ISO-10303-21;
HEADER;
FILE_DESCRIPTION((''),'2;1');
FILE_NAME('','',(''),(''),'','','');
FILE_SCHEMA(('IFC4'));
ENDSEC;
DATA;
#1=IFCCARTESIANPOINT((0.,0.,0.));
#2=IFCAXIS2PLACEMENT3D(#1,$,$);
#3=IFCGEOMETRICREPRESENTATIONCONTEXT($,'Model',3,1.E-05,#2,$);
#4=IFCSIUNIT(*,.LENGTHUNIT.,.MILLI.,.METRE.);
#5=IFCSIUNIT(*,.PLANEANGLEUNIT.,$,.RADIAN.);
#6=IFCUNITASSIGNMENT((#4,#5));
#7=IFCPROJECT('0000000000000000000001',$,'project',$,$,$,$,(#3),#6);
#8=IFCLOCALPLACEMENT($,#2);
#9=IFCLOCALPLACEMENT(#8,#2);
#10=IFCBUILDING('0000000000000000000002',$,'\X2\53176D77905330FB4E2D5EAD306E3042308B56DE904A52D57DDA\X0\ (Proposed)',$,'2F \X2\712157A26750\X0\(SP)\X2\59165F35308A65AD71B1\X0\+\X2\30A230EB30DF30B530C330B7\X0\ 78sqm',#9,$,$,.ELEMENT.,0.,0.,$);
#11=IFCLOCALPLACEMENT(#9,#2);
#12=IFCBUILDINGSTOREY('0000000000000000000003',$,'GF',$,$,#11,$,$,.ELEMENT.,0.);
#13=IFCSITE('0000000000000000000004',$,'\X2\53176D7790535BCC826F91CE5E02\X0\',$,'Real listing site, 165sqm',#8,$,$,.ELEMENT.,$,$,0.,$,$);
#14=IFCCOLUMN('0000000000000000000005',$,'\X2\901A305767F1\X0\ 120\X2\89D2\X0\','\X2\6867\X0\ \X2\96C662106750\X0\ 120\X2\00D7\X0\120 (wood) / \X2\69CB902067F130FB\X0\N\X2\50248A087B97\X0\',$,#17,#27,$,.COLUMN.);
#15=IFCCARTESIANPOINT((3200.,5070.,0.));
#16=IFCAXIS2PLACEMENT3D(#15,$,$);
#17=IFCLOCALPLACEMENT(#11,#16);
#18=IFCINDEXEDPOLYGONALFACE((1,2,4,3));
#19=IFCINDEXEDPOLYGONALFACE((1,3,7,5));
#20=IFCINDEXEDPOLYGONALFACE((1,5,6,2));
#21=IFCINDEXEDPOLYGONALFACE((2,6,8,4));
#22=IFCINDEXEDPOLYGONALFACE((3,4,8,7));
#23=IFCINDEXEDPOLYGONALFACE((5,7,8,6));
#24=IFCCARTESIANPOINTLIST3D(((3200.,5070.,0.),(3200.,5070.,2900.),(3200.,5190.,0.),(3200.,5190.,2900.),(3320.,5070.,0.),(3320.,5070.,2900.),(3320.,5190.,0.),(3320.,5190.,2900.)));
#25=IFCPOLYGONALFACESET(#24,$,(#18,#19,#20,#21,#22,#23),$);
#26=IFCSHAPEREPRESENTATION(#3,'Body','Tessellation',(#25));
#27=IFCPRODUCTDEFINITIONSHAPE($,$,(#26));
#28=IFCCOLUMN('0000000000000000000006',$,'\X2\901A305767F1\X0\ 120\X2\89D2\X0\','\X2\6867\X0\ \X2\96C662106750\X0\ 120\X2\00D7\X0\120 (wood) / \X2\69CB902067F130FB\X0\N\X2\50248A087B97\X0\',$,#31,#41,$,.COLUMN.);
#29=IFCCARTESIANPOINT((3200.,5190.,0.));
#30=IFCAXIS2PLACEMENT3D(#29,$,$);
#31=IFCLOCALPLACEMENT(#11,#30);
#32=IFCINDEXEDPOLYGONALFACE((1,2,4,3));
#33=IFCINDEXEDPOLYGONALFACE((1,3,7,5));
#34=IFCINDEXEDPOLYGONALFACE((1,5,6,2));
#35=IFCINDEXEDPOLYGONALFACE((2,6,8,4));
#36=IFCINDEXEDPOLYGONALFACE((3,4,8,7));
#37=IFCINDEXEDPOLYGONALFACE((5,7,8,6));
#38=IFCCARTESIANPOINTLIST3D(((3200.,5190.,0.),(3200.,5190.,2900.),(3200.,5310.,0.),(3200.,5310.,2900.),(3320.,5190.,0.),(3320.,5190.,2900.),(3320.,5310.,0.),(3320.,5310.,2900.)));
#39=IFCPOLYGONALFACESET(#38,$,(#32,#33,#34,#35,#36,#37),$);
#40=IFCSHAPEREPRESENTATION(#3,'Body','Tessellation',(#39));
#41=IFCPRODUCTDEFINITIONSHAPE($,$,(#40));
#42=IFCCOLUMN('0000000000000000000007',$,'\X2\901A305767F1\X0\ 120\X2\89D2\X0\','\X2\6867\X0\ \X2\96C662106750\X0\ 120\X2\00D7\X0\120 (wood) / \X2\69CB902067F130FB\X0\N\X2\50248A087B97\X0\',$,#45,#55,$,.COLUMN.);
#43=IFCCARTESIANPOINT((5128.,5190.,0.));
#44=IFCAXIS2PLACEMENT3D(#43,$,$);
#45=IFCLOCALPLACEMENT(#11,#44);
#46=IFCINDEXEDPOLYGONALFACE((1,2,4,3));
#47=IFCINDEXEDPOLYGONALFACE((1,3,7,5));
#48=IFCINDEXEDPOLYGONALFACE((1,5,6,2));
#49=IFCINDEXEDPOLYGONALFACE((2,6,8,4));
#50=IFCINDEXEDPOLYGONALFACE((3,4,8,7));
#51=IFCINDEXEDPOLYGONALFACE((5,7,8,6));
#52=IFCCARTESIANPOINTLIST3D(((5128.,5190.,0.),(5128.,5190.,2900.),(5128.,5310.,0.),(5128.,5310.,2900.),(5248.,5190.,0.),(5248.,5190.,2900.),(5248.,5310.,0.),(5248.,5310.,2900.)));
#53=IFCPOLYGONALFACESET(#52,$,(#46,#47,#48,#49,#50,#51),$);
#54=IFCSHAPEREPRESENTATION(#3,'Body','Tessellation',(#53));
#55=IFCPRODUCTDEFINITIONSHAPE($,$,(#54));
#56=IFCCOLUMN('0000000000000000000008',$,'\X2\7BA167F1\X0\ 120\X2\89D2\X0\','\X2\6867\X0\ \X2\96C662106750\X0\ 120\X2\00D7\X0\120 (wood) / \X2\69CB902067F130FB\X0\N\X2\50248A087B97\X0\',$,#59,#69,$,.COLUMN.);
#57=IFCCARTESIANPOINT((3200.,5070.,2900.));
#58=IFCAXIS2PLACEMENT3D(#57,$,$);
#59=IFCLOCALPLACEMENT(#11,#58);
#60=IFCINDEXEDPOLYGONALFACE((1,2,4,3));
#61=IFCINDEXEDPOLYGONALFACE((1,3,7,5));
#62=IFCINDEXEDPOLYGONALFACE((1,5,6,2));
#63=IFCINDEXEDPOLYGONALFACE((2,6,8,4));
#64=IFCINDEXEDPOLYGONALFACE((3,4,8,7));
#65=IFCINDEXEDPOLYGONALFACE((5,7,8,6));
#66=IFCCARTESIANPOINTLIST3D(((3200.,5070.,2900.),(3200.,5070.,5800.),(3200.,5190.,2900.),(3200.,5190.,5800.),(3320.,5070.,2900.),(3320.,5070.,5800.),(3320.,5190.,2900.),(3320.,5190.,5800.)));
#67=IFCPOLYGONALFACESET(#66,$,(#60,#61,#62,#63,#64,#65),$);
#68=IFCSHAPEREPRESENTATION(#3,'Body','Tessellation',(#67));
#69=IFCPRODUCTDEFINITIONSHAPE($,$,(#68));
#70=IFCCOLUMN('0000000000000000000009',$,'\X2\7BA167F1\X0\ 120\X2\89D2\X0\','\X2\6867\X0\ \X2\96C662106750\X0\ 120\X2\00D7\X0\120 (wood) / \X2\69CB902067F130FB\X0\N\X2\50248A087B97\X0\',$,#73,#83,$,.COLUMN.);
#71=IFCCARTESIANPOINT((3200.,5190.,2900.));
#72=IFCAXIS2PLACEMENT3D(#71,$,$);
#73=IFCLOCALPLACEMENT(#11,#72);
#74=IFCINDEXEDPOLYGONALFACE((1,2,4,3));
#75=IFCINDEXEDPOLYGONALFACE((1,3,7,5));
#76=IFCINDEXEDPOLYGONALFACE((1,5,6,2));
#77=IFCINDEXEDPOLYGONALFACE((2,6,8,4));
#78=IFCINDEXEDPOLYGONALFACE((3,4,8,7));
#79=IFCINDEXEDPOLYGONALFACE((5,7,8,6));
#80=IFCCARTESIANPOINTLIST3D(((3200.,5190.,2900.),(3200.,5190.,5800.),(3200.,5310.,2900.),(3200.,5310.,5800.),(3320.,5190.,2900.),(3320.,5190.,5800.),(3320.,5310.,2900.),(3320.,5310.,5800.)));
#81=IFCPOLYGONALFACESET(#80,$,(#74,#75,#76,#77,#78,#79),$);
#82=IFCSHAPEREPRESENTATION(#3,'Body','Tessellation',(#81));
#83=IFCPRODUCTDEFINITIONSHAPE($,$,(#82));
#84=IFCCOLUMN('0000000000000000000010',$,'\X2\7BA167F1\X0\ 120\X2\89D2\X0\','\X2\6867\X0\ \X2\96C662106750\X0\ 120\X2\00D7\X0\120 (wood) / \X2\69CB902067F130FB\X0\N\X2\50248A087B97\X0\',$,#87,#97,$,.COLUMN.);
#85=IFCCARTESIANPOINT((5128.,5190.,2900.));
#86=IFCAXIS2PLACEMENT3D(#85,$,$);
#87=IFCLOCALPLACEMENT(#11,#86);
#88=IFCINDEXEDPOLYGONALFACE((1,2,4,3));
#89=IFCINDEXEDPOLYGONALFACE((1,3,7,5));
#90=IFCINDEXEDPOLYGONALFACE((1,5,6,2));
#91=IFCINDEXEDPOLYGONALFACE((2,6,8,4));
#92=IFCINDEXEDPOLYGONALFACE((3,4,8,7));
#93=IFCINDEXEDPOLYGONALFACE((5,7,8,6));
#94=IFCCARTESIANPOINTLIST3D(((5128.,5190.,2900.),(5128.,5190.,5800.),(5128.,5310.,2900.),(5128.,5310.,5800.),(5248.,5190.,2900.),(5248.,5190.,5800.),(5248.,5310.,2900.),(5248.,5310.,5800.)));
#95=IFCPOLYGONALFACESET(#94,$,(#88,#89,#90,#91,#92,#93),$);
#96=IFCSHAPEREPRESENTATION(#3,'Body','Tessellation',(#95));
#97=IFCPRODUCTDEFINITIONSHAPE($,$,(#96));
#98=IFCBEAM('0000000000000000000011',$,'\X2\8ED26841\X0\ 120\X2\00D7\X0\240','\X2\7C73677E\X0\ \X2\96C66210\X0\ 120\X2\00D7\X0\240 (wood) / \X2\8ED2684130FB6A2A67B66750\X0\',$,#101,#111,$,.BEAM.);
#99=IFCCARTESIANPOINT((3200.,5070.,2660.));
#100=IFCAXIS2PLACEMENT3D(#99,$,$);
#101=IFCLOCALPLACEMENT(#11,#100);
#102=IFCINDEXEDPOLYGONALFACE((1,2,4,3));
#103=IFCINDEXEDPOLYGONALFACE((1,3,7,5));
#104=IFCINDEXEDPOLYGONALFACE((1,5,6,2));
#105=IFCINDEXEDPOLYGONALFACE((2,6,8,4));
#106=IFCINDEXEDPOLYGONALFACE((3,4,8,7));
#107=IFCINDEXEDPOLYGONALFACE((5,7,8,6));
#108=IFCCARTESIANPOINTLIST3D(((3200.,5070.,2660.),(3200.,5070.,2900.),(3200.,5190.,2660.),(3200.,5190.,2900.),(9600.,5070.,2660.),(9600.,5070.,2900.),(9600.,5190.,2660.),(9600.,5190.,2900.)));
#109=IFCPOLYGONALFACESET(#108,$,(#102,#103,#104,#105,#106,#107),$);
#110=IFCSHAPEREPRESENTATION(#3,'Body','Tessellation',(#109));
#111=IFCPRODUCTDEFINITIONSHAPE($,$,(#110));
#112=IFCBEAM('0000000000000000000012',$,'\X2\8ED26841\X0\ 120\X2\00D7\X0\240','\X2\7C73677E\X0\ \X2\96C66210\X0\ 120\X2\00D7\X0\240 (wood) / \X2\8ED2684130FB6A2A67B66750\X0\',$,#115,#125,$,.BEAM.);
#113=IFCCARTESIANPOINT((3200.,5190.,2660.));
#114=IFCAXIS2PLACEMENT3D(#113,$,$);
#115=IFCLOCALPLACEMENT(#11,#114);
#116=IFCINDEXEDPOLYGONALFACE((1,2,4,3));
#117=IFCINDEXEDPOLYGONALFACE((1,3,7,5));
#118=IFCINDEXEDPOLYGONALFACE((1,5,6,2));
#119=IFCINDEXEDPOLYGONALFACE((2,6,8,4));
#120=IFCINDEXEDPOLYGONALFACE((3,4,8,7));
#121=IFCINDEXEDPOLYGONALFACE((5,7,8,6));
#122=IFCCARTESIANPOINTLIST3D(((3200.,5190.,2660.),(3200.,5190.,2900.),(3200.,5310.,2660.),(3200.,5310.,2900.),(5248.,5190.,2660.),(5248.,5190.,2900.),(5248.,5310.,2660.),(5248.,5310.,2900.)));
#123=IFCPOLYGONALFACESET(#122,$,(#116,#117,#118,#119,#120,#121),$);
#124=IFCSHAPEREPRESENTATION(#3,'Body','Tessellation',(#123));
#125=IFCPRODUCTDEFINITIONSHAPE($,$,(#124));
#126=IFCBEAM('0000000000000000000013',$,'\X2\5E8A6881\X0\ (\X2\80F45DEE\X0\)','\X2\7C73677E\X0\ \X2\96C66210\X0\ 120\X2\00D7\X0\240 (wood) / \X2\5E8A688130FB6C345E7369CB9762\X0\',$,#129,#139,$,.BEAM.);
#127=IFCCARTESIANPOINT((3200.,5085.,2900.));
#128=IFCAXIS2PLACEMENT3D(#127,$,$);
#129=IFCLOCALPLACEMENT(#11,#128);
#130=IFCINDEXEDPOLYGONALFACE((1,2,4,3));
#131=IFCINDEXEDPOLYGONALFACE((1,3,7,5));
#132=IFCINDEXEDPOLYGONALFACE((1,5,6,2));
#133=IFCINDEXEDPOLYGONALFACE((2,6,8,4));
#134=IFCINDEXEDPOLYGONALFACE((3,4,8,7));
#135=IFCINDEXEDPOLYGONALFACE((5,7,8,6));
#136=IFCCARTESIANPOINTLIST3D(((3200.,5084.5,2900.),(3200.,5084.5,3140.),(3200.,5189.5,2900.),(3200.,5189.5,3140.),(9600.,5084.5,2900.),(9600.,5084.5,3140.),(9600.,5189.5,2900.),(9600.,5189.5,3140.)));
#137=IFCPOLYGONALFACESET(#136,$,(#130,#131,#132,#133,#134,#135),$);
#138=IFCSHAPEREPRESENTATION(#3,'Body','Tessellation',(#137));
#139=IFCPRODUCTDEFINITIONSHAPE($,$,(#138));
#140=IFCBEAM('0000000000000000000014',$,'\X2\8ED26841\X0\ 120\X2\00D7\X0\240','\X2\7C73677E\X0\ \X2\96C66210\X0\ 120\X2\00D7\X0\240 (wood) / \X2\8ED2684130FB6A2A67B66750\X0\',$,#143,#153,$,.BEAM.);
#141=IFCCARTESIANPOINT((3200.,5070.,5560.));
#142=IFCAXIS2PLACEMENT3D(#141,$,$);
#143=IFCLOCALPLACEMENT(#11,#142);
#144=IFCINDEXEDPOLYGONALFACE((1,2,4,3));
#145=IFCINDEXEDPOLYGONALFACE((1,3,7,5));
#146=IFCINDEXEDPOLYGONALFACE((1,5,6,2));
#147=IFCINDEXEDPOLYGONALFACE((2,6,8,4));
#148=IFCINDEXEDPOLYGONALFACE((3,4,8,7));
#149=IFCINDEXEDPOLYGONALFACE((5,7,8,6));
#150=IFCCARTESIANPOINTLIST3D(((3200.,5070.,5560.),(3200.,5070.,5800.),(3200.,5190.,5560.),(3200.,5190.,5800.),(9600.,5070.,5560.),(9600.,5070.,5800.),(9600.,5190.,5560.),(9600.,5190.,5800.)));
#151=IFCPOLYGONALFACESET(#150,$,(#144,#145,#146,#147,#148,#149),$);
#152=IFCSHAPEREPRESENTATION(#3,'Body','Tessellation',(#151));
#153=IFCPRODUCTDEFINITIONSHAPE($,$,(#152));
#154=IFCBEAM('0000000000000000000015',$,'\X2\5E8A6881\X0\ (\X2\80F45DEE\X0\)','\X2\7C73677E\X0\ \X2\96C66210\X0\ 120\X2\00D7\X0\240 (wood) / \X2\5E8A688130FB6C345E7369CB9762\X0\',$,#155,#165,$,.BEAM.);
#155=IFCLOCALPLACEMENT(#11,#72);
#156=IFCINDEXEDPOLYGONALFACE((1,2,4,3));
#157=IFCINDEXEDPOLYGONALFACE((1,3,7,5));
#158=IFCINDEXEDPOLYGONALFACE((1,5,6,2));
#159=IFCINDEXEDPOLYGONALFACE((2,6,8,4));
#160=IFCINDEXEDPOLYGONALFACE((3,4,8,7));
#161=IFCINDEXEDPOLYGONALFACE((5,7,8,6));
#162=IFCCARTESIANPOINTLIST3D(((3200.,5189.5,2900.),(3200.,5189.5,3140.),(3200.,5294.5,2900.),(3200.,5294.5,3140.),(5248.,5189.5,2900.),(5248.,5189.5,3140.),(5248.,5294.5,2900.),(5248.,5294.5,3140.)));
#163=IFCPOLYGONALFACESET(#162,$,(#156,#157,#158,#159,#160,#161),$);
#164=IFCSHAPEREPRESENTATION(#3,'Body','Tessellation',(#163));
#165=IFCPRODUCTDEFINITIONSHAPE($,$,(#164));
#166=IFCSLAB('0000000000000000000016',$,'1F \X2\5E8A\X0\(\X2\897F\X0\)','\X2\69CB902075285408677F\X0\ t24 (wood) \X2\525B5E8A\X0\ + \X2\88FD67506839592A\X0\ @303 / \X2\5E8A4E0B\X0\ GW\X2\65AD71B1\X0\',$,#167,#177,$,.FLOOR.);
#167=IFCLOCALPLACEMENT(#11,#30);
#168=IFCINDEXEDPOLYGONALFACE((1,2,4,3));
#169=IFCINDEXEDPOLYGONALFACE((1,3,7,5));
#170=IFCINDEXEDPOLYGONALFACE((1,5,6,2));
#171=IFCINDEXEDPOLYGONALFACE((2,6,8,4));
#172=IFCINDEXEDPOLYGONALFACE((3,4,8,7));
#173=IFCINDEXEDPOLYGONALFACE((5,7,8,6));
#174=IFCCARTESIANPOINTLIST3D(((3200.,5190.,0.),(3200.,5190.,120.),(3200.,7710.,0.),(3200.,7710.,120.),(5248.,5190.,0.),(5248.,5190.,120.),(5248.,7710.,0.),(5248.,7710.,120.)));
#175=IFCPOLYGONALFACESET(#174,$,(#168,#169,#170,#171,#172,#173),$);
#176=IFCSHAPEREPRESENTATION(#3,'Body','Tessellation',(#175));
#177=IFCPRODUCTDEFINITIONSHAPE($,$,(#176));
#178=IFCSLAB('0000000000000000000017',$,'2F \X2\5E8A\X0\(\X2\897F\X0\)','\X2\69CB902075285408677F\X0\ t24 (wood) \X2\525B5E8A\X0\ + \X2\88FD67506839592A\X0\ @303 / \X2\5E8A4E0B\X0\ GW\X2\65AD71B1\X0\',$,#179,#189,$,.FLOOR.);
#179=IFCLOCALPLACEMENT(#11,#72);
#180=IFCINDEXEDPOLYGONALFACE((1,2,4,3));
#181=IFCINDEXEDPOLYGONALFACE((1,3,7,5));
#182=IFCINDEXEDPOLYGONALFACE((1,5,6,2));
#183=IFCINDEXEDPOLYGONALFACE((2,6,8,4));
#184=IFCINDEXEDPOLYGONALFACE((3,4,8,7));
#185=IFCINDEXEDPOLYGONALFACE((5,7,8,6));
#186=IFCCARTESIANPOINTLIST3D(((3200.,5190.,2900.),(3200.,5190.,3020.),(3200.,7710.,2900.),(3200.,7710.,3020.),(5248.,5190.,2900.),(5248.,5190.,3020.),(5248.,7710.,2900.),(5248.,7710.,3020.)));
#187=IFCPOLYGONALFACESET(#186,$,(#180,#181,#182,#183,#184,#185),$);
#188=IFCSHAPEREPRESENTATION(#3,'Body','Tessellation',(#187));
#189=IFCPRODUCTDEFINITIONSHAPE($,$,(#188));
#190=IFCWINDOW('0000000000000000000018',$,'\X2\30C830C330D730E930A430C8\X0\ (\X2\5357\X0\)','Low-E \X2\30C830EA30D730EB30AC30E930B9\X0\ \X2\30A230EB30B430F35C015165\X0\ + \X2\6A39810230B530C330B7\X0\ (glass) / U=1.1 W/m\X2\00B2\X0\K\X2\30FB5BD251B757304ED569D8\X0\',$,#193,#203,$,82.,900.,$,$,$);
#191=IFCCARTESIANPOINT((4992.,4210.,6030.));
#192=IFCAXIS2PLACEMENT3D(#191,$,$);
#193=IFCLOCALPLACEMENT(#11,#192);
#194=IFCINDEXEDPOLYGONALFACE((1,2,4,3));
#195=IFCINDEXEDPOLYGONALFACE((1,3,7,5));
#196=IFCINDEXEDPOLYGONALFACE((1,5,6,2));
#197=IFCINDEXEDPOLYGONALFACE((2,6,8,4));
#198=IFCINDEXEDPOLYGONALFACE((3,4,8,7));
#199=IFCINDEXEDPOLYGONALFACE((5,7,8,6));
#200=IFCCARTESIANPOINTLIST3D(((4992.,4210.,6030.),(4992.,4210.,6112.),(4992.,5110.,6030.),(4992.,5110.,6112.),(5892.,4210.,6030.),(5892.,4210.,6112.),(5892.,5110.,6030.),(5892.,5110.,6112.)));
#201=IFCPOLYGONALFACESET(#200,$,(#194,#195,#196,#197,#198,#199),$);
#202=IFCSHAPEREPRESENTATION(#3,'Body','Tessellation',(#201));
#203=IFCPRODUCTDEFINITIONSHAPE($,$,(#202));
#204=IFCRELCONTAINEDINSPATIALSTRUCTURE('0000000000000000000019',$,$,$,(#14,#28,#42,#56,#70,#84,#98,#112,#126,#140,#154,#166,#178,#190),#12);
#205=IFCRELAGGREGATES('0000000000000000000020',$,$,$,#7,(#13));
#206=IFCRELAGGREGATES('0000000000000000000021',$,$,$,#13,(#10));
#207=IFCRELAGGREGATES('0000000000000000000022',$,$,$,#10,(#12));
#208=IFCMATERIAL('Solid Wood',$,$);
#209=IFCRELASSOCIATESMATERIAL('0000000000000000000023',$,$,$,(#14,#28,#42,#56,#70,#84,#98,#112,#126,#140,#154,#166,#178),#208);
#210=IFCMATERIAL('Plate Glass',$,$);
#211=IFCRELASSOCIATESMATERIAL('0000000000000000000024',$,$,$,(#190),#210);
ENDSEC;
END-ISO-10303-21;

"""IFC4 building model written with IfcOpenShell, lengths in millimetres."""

from ifc_helpers import new_model, si_unit, frame, frame_2d, origin, place, context, project, spatial, rectangle, extrude, material, element, save


model = new_model("IFC4")

# Units and contexts
model_context = context("Model", 3, precision=1e-05, world=origin())
ifc_project = project(units=[si_unit("LENGTHUNIT", "METRE", prefix="MILLI"), si_unit("PLANEANGLEUNIT", "RADIAN")], contexts=[model_context])

# Site, building, storey
site_placement = place(None, origin())
site = spatial("IfcSite", under=ifc_project, at=site_placement, Name="北海道富良野市", ObjectType="Real listing site, 165sqm", CompositionType="ELEMENT", RefElevation=0.0)
building_placement = place(site_placement, origin())
building = spatial("IfcBuilding", under=site, at=building_placement, Name="北海道・中庭のある回遊動線 (Proposed)", ObjectType="2F 無垢材(SP)外張り断熱+アルミサッシ 78sqm", CompositionType="ELEMENT", ElevationOfRefHeight=0.0, ElevationOfTerrain=0.0)
storey_placement = place(building_placement, origin())
storey = spatial("IfcBuildingStorey", under=building, at=storey_placement, Name="GF", CompositionType="ELEMENT", Elevation=0.0)

# Columns
ifc_material_1 = material(Name="Solid Wood")
column_1_placement = place(storey_placement, frame((3200.0, 5070.0, 0.0)))
element("IfcColumn", 1, at=column_1_placement, inside=storey, material=ifc_material_1, Name="通し柱 120角", Description="桧 集成材 120×120 (wood) / 構造柱・N値計算", PredefinedType="COLUMN", context=model_context, shape_type="SweptSolid", body=[
    extrude(rectangle(XDim=120.0, YDim=120.0, at=frame_2d((60.0, 60.0))), frame((3200.0, 5070.0, 0.0)), (0.0, 0.0, 1.0), 2900.0),
])
column_2_placement = place(storey_placement, frame((3200.0, 5190.0, 0.0)))
element("IfcColumn", 2, at=column_2_placement, inside=storey, material=ifc_material_1, Name="通し柱 120角", Description="桧 集成材 120×120 (wood) / 構造柱・N値計算", PredefinedType="COLUMN", context=model_context, shape_type="SweptSolid", body=[
    extrude(rectangle(XDim=120.0, YDim=120.0, at=frame_2d((60.0, 60.0))), frame((3200.0, 5190.0, 0.0)), (0.0, 0.0, 1.0), 2900.0),
])
column_3_placement = place(storey_placement, frame((5128.0, 5190.0, 0.0)))
element("IfcColumn", 3, at=column_3_placement, inside=storey, material=ifc_material_1, Name="通し柱 120角", Description="桧 集成材 120×120 (wood) / 構造柱・N値計算", PredefinedType="COLUMN", context=model_context, shape_type="SweptSolid", body=[
    extrude(rectangle(XDim=120.0, YDim=120.0, at=frame_2d((60.0, 60.0))), frame((5128.0, 5190.0, 0.0)), (0.0, 0.0, 1.0), 2900.0),
])
column_4_placement = place(storey_placement, frame((3200.0, 5070.0, 2900.0)))
element("IfcColumn", 4, at=column_4_placement, inside=storey, material=ifc_material_1, Name="管柱 120角", Description="桧 集成材 120×120 (wood) / 構造柱・N値計算", PredefinedType="COLUMN", context=model_context, shape_type="SweptSolid", body=[
    extrude(rectangle(XDim=120.0, YDim=120.0, at=frame_2d((60.0, 60.0))), frame((3200.0, 5070.0, 2900.0)), (0.0, 0.0, 1.0), 2900.0),
])
column_5_placement = place(storey_placement, frame((3200.0, 5190.0, 2900.0)))
element("IfcColumn", 5, at=column_5_placement, inside=storey, material=ifc_material_1, Name="管柱 120角", Description="桧 集成材 120×120 (wood) / 構造柱・N値計算", PredefinedType="COLUMN", context=model_context, shape_type="SweptSolid", body=[
    extrude(rectangle(XDim=120.0, YDim=120.0, at=frame_2d((60.0, 60.0))), frame((3200.0, 5190.0, 2900.0)), (0.0, 0.0, 1.0), 2900.0),
])
column_6_placement = place(storey_placement, frame((5128.0, 5190.0, 2900.0)))
element("IfcColumn", 6, at=column_6_placement, inside=storey, material=ifc_material_1, Name="管柱 120角", Description="桧 集成材 120×120 (wood) / 構造柱・N値計算", PredefinedType="COLUMN", context=model_context, shape_type="SweptSolid", body=[
    extrude(rectangle(XDim=120.0, YDim=120.0, at=frame_2d((60.0, 60.0))), frame((5128.0, 5190.0, 2900.0)), (0.0, 0.0, 1.0), 2900.0),
])

# Beams
beam_1_placement = place(storey_placement, frame((3200.0, 5070.0, 2660.0)))
element("IfcBeam", 7, at=beam_1_placement, inside=storey, material=ifc_material_1, Name="軒桁 120×240", Description="米松 集成 120×240 (wood) / 軒桁・横架材", PredefinedType="BEAM", context=model_context, shape_type="SweptSolid", body=[
    extrude(rectangle(XDim=6400.0, YDim=120.0, at=frame_2d((3200.0, 60.0))), frame((3200.0, 5070.0, 2660.0)), (0.0, 0.0, 1.0), 240.0),
])
beam_2_placement = place(storey_placement, frame((3200.0, 5190.0, 2660.0)))
element("IfcBeam", 8, at=beam_2_placement, inside=storey, material=ifc_material_1, Name="軒桁 120×240", Description="米松 集成 120×240 (wood) / 軒桁・横架材", PredefinedType="BEAM", context=model_context, shape_type="SweptSolid", body=[
    extrude(rectangle(XDim=2048.0, YDim=120.0, at=frame_2d((1024.0, 60.0))), frame((3200.0, 5190.0, 2660.0)), (0.0, 0.0, 1.0), 240.0),
])
beam_3_placement = place(storey_placement, frame((3200.0, 5085.0, 2900.0)))
element("IfcBeam", 9, at=beam_3_placement, inside=storey, material=ifc_material_1, Name="床梁 (胴差)", Description="米松 集成 120×240 (wood) / 床梁・水平構面", PredefinedType="BEAM", context=model_context, shape_type="SweptSolid", body=[
    extrude(rectangle(XDim=6400.0, YDim=105.0, at=frame_2d((3200.0, 52.0))), frame((3200.0, 5085.0, 2900.0)), (0.0, 0.0, 1.0), 240.0),
])
beam_4_placement = place(storey_placement, frame((3200.0, 5070.0, 5560.0)))
element("IfcBeam", 10, at=beam_4_placement, inside=storey, material=ifc_material_1, Name="軒桁 120×240", Description="米松 集成 120×240 (wood) / 軒桁・横架材", PredefinedType="BEAM", context=model_context, shape_type="SweptSolid", body=[
    extrude(rectangle(XDim=6400.0, YDim=120.0, at=frame_2d((3200.0, 60.0))), frame((3200.0, 5070.0, 5560.0)), (0.0, 0.0, 1.0), 240.0),
])
beam_5_placement = place(storey_placement, frame((3200.0, 5190.0, 2900.0)))
element("IfcBeam", 11, at=beam_5_placement, inside=storey, material=ifc_material_1, Name="床梁 (胴差)", Description="米松 集成 120×240 (wood) / 床梁・水平構面", PredefinedType="BEAM", context=model_context, shape_type="SweptSolid", body=[
    extrude(rectangle(XDim=2048.0, YDim=105.0, at=frame_2d((1024.0, 52.0))), frame((3200.0, 5190.0, 2900.0)), (0.0, 0.0, 1.0), 240.0),
])

# Slabs
slab_1_placement = place(storey_placement, frame((3200.0, 5190.0, 0.0)))
element("IfcSlab", 12, at=slab_1_placement, inside=storey, material=ifc_material_1, Name="1F 床(西)", Description="構造用合板 t24 (wood) 剛床 + 製材根太 @303 / 床下 GW断熱", PredefinedType="FLOOR", context=model_context, shape_type="SweptSolid", body=[
    extrude(rectangle(XDim=2048.0, YDim=2520.0, at=frame_2d((1024.0, 1260.0))), frame((3200.0, 5190.0, 0.0)), (0.0, 0.0, 1.0), 120.0),
])
slab_2_placement = place(storey_placement, frame((3200.0, 5190.0, 2900.0)))
element("IfcSlab", 13, at=slab_2_placement, inside=storey, material=ifc_material_1, Name="2F 床(西)", Description="構造用合板 t24 (wood) 剛床 + 製材根太 @303 / 床下 GW断熱", PredefinedType="FLOOR", context=model_context, shape_type="SweptSolid", body=[
    extrude(rectangle(XDim=2048.0, YDim=2520.0, at=frame_2d((1024.0, 1260.0))), frame((3200.0, 5190.0, 2900.0)), (0.0, 0.0, 1.0), 120.0),
])

# Window
ifc_material_2 = material(Name="Plate Glass")
window_placement = place(storey_placement, frame((4992.0, 4210.0, 6030.0)))
element("IfcWindow", 14, at=window_placement, inside=storey, material=ifc_material_2, Name="トップライト (南)", Description="Low-E トリプルガラス アルゴン封入 + 樹脂サッシ (glass) / U=1.1 W/m²K・寒冷地仕様", OverallHeight=82.0, OverallWidth=900.0, context=model_context, shape_type="SweptSolid", body=[
    extrude(rectangle(XDim=900.0, YDim=900.0, at=frame_2d((450.0, 450.0))), frame((4992.0, 4210.0, 6030.0)), (0.0, 0.0, 1.0), 82.0),
])

save(model, "model.ifc")
